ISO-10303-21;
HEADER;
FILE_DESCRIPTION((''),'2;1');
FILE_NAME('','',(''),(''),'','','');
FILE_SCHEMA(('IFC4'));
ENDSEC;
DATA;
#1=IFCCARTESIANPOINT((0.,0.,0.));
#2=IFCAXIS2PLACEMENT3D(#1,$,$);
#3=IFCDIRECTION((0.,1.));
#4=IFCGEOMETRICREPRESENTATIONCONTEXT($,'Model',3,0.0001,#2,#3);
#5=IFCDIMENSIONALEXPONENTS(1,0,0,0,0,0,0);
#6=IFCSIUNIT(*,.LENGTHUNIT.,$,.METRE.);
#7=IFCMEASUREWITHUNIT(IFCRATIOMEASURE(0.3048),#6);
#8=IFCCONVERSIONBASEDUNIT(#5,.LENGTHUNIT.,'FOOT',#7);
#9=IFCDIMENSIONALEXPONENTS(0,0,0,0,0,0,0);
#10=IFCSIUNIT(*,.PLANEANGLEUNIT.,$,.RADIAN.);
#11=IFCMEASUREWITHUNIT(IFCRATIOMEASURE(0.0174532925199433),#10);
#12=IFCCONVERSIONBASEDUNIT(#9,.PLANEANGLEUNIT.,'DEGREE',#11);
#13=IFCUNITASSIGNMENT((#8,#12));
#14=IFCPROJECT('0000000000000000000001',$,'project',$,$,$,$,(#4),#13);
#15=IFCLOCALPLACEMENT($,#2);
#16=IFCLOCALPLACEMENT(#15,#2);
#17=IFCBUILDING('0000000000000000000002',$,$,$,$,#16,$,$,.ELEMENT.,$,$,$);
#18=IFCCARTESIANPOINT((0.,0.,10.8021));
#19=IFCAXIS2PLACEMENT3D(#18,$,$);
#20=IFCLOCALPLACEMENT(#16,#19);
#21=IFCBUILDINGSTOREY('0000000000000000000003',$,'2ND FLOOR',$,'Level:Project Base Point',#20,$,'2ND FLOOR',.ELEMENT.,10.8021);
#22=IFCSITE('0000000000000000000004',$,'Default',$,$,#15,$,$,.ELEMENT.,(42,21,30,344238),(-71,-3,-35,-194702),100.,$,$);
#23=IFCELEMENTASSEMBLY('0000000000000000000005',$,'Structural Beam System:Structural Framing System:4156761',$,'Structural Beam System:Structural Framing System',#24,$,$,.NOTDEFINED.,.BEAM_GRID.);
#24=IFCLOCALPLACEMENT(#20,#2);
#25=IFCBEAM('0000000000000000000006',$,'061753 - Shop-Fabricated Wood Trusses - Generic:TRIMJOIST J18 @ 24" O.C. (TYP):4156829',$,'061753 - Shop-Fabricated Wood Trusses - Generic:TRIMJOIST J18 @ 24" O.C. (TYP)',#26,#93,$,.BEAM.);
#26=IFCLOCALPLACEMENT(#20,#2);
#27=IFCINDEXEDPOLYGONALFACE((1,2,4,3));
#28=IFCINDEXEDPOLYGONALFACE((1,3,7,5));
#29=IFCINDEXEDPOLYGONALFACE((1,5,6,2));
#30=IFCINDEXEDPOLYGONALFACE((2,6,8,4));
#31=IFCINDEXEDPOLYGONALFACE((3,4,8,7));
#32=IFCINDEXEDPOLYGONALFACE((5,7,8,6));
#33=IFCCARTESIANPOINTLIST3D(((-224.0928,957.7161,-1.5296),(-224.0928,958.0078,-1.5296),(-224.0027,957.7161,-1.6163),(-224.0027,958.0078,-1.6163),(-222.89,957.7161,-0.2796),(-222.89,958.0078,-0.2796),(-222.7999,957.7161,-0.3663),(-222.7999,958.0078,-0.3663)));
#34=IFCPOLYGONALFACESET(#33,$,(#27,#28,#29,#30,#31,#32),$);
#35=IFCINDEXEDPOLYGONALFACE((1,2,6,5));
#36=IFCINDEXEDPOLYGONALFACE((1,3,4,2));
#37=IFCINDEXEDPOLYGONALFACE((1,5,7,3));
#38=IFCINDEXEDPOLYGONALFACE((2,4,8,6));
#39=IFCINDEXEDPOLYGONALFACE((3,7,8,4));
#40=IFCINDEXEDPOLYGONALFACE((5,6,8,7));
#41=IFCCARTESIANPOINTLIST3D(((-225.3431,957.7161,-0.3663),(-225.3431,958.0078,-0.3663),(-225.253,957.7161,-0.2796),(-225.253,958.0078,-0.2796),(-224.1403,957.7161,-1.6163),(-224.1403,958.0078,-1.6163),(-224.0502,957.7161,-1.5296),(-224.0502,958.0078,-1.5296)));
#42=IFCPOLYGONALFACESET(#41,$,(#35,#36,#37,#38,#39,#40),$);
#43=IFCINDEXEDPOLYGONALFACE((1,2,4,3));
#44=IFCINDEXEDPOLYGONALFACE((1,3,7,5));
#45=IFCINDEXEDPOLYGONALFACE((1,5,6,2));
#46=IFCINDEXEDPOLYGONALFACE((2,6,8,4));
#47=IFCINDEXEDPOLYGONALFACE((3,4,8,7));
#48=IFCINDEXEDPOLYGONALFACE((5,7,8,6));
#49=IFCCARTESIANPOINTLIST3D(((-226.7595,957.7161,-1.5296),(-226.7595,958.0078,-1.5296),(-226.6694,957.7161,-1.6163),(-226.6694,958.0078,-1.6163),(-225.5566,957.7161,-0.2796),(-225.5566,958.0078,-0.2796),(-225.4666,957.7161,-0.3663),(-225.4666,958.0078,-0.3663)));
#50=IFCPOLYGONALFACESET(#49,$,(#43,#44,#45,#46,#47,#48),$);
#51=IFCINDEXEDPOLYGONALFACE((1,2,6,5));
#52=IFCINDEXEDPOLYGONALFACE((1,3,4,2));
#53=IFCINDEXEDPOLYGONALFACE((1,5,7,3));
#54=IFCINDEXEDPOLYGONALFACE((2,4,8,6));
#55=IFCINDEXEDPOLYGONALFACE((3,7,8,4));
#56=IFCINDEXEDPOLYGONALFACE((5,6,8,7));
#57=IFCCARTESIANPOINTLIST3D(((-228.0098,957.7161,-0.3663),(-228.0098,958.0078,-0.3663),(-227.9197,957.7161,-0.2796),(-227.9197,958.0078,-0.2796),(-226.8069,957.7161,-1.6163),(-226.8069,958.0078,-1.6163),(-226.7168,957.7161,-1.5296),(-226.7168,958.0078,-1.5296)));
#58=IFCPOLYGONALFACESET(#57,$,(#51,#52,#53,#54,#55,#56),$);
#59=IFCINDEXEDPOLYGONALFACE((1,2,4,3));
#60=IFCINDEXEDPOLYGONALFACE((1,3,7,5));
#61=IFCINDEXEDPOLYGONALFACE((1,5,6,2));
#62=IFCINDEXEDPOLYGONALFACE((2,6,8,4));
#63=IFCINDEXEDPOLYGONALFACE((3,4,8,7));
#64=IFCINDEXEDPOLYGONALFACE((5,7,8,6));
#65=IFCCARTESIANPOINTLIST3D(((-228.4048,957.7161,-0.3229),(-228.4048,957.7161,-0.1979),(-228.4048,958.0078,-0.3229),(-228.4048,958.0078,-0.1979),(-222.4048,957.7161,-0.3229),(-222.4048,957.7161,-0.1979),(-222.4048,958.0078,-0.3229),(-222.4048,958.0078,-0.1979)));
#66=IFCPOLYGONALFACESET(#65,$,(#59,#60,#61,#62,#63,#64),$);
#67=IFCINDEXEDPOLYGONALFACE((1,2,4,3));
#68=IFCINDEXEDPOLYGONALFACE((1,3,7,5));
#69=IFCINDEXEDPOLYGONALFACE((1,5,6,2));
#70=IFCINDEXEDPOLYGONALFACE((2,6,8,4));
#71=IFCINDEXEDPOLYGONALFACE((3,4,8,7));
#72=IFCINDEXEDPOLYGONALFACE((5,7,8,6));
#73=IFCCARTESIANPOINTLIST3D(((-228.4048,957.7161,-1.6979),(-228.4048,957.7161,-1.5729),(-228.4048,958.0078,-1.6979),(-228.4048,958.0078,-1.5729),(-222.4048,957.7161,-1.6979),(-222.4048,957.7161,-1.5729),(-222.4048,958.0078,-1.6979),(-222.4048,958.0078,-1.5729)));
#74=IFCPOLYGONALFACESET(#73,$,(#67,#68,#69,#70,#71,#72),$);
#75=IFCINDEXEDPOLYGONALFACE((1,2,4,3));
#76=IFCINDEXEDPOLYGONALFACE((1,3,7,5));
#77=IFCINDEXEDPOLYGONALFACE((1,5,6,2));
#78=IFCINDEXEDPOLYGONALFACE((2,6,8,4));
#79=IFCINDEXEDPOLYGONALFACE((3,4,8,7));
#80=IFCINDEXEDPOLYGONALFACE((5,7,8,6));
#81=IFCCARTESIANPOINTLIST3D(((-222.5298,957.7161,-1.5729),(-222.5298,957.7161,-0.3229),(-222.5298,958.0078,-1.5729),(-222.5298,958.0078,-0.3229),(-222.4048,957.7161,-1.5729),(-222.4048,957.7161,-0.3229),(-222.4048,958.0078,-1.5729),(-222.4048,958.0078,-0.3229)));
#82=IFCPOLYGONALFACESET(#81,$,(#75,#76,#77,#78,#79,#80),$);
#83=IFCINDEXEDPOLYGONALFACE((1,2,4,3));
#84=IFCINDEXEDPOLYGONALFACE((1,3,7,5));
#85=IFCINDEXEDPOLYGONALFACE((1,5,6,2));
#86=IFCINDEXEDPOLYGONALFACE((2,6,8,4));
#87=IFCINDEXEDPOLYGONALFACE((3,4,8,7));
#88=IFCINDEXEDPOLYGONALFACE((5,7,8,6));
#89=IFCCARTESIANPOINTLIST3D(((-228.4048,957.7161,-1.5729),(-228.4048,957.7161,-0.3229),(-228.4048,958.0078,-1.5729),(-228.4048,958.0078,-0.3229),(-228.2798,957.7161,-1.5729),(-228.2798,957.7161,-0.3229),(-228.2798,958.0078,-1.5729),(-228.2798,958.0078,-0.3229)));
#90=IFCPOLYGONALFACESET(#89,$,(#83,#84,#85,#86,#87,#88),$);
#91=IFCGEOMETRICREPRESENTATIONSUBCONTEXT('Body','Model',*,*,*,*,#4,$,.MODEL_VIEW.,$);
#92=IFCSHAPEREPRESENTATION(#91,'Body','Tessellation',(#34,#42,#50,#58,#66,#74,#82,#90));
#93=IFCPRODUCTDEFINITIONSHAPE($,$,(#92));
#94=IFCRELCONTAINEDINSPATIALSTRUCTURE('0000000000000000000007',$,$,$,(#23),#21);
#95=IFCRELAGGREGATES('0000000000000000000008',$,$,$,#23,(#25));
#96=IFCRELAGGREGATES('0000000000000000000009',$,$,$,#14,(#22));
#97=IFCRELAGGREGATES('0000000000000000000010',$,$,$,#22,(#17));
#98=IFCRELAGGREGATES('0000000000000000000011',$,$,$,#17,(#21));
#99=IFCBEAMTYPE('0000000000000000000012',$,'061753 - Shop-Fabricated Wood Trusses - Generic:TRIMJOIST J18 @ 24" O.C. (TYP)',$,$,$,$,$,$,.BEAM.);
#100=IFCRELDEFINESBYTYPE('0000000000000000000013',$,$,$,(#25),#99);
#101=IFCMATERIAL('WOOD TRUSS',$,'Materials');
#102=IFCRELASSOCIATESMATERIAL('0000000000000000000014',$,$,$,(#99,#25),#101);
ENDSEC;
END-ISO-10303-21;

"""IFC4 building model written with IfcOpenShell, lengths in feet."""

from ifc_helpers import new_model, entity, si_unit, converted_unit, direction, frame, frame_2d, origin, origin_2d_with_axis, place, context, subcontext, project, spatial, rectangle, extrude, source, transform, mapped, material, material_profile, profile_set, profile_usage, type_object, type_shapes, element, aggregate, save


model = new_model("IFC4")

# Units and contexts
model_context = context("Model", 3, precision=0.0001, world=origin(), true_north=direction((0.0, 1.0)))
body_context = subcontext(model_context, "Body", "Model", "MODEL_VIEW")
ifc_project = project(units=[converted_unit("LENGTHUNIT", "FOOT", entity("IfcRatioMeasure", 0.3048), si_unit("LENGTHUNIT", "METRE"), dimensions=[1, 0, 0, 0, 0, 0, 0]), converted_unit("PLANEANGLEUNIT", "DEGREE", entity("IfcRatioMeasure", 0.0174532925199433), si_unit("PLANEANGLEUNIT", "RADIAN"), dimensions=[0, 0, 0, 0, 0, 0, 0])], contexts=[model_context])

# Site, building, storey
site_placement = place(None, origin())
site = spatial("IfcSite", under=ifc_project, at=site_placement, Name="Default", CompositionType="ELEMENT", RefLatitude=(42, 21, 30, 344238), RefLongitude=(-71, -3, -35, -194702), RefElevation=100.0)
building_placement = place(site_placement, origin())
building = spatial("IfcBuilding", under=site, at=building_placement, CompositionType="ELEMENT")
storey_placement = place(building_placement, frame((0.0, 0.0, 10.8021)))
storey = spatial("IfcBuildingStorey", under=building, at=storey_placement, Name="2ND FLOOR", ObjectType="Level:Project Base Point", LongName="2ND FLOOR", CompositionType="ELEMENT", Elevation=10.8021)

# Element assembly, beam
assembly_1_placement = place(storey_placement, origin())
assembly_1 = element("IfcElementAssembly", 1, at=assembly_1_placement, inside=storey, Name="Structural Beam System:Structural Framing System:4156761", ObjectType="Structural Beam System:Structural Framing System", AssemblyPlace="NOTDEFINED", PredefinedType="BEAM_GRID")
ifc_material_1 = material(Name="WOOD TRUSS", Category="Materials")
ifc_material_profile_1 = material_profile(ifc_material_1, rectangle(XDim=1.7347, YDim=0.125, at=frame_2d((0.0, 0.0), x_axis=(1.0, 0.0))), Name="TRIMJOIST J18 @ 24\" O.C. (TYP)")
ifc_material_profile_2 = material_profile(ifc_material_1, rectangle(XDim=1.7347, YDim=0.125, at=frame_2d((0.0, 0.0), x_axis=(1.0, 0.0))), Name="TRIMJOIST J18 @ 24\" O.C. (TYP)")
ifc_material_profile_3 = material_profile(ifc_material_1, rectangle(XDim=1.7347, YDim=0.125, at=frame_2d((0.0, 0.0), x_axis=(1.0, 0.0))), Name="TRIMJOIST J18 @ 24\" O.C. (TYP)")
ifc_material_profile_4 = material_profile(ifc_material_1, rectangle(XDim=1.7347, YDim=0.125, at=frame_2d((0.0, 0.0), x_axis=(1.0, 0.0))), Name="TRIMJOIST J18 @ 24\" O.C. (TYP)")
ifc_material_profile_5 = material_profile(ifc_material_1, rectangle(XDim=1.7347, YDim=0.125, at=frame_2d((0.0, 0.0), x_axis=(1.0, 0.0))), Name="TRIMJOIST J18 @ 24\" O.C. (TYP)")
ifc_material_profile_6 = material_profile(ifc_material_1, rectangle(XDim=1.7347, YDim=0.125, at=frame_2d((0.0, 0.0), x_axis=(1.0, 0.0))), Name="TRIMJOIST J18 @ 24\" O.C. (TYP)")
ifc_material_profile_7 = material_profile(ifc_material_1, rectangle(XDim=1.7347, YDim=0.125, at=frame_2d((0.0, 0.0), x_axis=(1.0, 0.0))), Name="TRIMJOIST J18 @ 24\" O.C. (TYP)")
ifc_material_profile_8 = material_profile(ifc_material_1, rectangle(XDim=1.7347, YDim=0.125, at=frame_2d((0.0, 0.0), x_axis=(1.0, 0.0))), Name="TRIMJOIST J18 @ 24\" O.C. (TYP)")
ifc_material_profile_9 = material_profile(ifc_material_1, rectangle(XDim=1.7347, YDim=0.125, at=frame_2d((0.0, 0.0), x_axis=(1.0, 0.0))), Name="TRIMJOIST J18 @ 24\" O.C. (TYP)")
ifc_material_profile_10 = material_profile(ifc_material_1, rectangle(XDim=1.7347, YDim=0.125, at=origin_2d_with_axis()), Name="TRIMJOIST J18 @ 24\" O.C. (TYP)")
ifc_material_profile_11 = material_profile(ifc_material_1, rectangle(XDim=0.125, YDim=0.2917, at=origin_2d_with_axis()), Name="TRIMJOIST J18 @ 24\" O.C. (TYP)")
ifc_material_profile_12 = material_profile(ifc_material_1, rectangle(XDim=0.125, YDim=0.2917, at=origin_2d_with_axis()), Name="TRIMJOIST J18 @ 24\" O.C. (TYP)")
ifc_material_profile_13 = material_profile(ifc_material_1, rectangle(XDim=1.25, YDim=0.2917, at=origin_2d_with_axis()), Name="TRIMJOIST J18 @ 24\" O.C. (TYP)")
ifc_material_profile_14 = material_profile(ifc_material_1, rectangle(XDim=1.25, YDim=0.2917, at=origin_2d_with_axis()), Name="TRIMJOIST J18 @ 24\" O.C. (TYP)")
ifc_profile_set_1 = profile_set([ifc_material_profile_1, ifc_material_profile_2, ifc_material_profile_3, ifc_material_profile_4, ifc_material_profile_5, ifc_material_profile_6, ifc_material_profile_7, ifc_material_profile_8, ifc_material_profile_9, ifc_material_profile_10, ifc_material_profile_11, ifc_material_profile_12, ifc_material_profile_13, ifc_material_profile_14], Name="TRIMJOIST J18 @ 24\" O.C. (TYP)")
ifc_profile_usage_1 = profile_usage(ifc_profile_set_1, cardinal=8)
beam_type_1 = type_object("IfcBeamType", Name="061753 - Shop-Fabricated Wood Trusses - Generic:TRIMJOIST J18 @ 24\" O.C. (TYP)", PredefinedType="BEAM", material=ifc_profile_set_1)
shared_shape_1 = source(origin(), body_context, "Body", "SweptSolid", [
    extrude(rectangle(XDim=1.7347, YDim=0.125, at=frame_2d((0.0, 0.0), x_axis=(1.0, 0.0))), frame((1.9585, -0.1458, 0.0), z_axis=(0.0, 1.0, 0.0), x_axis=(0.693383, 0.0, 0.720569)), (0.0, 0.0, 1.0), 0.2917),
    extrude(rectangle(XDim=1.7347, YDim=0.125, at=frame_2d((0.0, 0.0), x_axis=(1.0, 0.0))), frame((0.7082, -0.1458, 0.0), z_axis=(0.0, 1.0, 0.0), x_axis=(0.693383, 0.0, -0.720569)), (0.0, 0.0, 1.0), 0.2917),
    extrude(rectangle(XDim=1.7347, YDim=0.125, at=frame_2d((0.0, 0.0), x_axis=(1.0, 0.0))), frame((-0.7082, -0.1458, 0.0), z_axis=(0.0, 1.0, 0.0), x_axis=(0.693383, 0.0, 0.720569)), (0.0, 0.0, 1.0), 0.2917),
    extrude(rectangle(XDim=1.7347, YDim=0.125, at=frame_2d((0.0, 0.0), x_axis=(1.0, 0.0))), frame((-1.9585, -0.1458, 0.0), z_axis=(0.0, 1.0, 0.0), x_axis=(0.693383, 0.0, -0.720569)), (0.0, 0.0, 1.0), 0.2917),
    extrude(rectangle(XDim=0.125, YDim=0.2917, at=origin_2d_with_axis()), frame((-3.0, 0.0, 0.6875), z_axis=(1.0, 0.0, 0.0), x_axis=(0.0, 0.0, -1.0)), (0.0, 0.0, 1.0), 6.0),
    extrude(rectangle(XDim=0.125, YDim=0.2917, at=origin_2d_with_axis()), frame((-3.0, 0.0, -0.6875), z_axis=(1.0, 0.0, 0.0), x_axis=(0.0, 0.0, -1.0)), (0.0, 0.0, 1.0), 6.0),
    extrude(rectangle(XDim=1.25, YDim=0.2917, at=origin_2d_with_axis()), frame((2.875, 0.0, 0.0), z_axis=(1.0, 0.0, 0.0), x_axis=(0.0, 0.0, -1.0)), (0.0, 0.0, 1.0), 0.125),
    extrude(rectangle(XDim=1.25, YDim=0.2917, at=origin_2d_with_axis()), frame((-3.0, 0.0, 0.0), z_axis=(1.0, 0.0, 0.0), x_axis=(0.0, 0.0, -1.0)), (0.0, 0.0, 1.0), 0.125),
])
type_shapes(beam_type_1, [shared_shape_1])
beam_1_placement = place(assembly_1_placement, frame((-225.4048, 957.8619, -0.9479)))
beam_1 = element("IfcBeam", 2, at=beam_1_placement, type_object=beam_type_1, material=ifc_profile_usage_1, Name="061753 - Shop-Fabricated Wood Trusses - Generic:TRIMJOIST J18 @ 24\" O.C. (TYP):4156829", ObjectType="061753 - Shop-Fabricated Wood Trusses - Generic:TRIMJOIST J18 @ 24\" O.C. (TYP)", PredefinedType="BEAM", context=body_context, shape_type="MappedRepresentation", body=[
    mapped(shared_shape_1, transform((0.0, 0.0, 0.0), scale=1.0)),
])
aggregate(assembly_1, [beam_1])

save(model, "model.ifc")
